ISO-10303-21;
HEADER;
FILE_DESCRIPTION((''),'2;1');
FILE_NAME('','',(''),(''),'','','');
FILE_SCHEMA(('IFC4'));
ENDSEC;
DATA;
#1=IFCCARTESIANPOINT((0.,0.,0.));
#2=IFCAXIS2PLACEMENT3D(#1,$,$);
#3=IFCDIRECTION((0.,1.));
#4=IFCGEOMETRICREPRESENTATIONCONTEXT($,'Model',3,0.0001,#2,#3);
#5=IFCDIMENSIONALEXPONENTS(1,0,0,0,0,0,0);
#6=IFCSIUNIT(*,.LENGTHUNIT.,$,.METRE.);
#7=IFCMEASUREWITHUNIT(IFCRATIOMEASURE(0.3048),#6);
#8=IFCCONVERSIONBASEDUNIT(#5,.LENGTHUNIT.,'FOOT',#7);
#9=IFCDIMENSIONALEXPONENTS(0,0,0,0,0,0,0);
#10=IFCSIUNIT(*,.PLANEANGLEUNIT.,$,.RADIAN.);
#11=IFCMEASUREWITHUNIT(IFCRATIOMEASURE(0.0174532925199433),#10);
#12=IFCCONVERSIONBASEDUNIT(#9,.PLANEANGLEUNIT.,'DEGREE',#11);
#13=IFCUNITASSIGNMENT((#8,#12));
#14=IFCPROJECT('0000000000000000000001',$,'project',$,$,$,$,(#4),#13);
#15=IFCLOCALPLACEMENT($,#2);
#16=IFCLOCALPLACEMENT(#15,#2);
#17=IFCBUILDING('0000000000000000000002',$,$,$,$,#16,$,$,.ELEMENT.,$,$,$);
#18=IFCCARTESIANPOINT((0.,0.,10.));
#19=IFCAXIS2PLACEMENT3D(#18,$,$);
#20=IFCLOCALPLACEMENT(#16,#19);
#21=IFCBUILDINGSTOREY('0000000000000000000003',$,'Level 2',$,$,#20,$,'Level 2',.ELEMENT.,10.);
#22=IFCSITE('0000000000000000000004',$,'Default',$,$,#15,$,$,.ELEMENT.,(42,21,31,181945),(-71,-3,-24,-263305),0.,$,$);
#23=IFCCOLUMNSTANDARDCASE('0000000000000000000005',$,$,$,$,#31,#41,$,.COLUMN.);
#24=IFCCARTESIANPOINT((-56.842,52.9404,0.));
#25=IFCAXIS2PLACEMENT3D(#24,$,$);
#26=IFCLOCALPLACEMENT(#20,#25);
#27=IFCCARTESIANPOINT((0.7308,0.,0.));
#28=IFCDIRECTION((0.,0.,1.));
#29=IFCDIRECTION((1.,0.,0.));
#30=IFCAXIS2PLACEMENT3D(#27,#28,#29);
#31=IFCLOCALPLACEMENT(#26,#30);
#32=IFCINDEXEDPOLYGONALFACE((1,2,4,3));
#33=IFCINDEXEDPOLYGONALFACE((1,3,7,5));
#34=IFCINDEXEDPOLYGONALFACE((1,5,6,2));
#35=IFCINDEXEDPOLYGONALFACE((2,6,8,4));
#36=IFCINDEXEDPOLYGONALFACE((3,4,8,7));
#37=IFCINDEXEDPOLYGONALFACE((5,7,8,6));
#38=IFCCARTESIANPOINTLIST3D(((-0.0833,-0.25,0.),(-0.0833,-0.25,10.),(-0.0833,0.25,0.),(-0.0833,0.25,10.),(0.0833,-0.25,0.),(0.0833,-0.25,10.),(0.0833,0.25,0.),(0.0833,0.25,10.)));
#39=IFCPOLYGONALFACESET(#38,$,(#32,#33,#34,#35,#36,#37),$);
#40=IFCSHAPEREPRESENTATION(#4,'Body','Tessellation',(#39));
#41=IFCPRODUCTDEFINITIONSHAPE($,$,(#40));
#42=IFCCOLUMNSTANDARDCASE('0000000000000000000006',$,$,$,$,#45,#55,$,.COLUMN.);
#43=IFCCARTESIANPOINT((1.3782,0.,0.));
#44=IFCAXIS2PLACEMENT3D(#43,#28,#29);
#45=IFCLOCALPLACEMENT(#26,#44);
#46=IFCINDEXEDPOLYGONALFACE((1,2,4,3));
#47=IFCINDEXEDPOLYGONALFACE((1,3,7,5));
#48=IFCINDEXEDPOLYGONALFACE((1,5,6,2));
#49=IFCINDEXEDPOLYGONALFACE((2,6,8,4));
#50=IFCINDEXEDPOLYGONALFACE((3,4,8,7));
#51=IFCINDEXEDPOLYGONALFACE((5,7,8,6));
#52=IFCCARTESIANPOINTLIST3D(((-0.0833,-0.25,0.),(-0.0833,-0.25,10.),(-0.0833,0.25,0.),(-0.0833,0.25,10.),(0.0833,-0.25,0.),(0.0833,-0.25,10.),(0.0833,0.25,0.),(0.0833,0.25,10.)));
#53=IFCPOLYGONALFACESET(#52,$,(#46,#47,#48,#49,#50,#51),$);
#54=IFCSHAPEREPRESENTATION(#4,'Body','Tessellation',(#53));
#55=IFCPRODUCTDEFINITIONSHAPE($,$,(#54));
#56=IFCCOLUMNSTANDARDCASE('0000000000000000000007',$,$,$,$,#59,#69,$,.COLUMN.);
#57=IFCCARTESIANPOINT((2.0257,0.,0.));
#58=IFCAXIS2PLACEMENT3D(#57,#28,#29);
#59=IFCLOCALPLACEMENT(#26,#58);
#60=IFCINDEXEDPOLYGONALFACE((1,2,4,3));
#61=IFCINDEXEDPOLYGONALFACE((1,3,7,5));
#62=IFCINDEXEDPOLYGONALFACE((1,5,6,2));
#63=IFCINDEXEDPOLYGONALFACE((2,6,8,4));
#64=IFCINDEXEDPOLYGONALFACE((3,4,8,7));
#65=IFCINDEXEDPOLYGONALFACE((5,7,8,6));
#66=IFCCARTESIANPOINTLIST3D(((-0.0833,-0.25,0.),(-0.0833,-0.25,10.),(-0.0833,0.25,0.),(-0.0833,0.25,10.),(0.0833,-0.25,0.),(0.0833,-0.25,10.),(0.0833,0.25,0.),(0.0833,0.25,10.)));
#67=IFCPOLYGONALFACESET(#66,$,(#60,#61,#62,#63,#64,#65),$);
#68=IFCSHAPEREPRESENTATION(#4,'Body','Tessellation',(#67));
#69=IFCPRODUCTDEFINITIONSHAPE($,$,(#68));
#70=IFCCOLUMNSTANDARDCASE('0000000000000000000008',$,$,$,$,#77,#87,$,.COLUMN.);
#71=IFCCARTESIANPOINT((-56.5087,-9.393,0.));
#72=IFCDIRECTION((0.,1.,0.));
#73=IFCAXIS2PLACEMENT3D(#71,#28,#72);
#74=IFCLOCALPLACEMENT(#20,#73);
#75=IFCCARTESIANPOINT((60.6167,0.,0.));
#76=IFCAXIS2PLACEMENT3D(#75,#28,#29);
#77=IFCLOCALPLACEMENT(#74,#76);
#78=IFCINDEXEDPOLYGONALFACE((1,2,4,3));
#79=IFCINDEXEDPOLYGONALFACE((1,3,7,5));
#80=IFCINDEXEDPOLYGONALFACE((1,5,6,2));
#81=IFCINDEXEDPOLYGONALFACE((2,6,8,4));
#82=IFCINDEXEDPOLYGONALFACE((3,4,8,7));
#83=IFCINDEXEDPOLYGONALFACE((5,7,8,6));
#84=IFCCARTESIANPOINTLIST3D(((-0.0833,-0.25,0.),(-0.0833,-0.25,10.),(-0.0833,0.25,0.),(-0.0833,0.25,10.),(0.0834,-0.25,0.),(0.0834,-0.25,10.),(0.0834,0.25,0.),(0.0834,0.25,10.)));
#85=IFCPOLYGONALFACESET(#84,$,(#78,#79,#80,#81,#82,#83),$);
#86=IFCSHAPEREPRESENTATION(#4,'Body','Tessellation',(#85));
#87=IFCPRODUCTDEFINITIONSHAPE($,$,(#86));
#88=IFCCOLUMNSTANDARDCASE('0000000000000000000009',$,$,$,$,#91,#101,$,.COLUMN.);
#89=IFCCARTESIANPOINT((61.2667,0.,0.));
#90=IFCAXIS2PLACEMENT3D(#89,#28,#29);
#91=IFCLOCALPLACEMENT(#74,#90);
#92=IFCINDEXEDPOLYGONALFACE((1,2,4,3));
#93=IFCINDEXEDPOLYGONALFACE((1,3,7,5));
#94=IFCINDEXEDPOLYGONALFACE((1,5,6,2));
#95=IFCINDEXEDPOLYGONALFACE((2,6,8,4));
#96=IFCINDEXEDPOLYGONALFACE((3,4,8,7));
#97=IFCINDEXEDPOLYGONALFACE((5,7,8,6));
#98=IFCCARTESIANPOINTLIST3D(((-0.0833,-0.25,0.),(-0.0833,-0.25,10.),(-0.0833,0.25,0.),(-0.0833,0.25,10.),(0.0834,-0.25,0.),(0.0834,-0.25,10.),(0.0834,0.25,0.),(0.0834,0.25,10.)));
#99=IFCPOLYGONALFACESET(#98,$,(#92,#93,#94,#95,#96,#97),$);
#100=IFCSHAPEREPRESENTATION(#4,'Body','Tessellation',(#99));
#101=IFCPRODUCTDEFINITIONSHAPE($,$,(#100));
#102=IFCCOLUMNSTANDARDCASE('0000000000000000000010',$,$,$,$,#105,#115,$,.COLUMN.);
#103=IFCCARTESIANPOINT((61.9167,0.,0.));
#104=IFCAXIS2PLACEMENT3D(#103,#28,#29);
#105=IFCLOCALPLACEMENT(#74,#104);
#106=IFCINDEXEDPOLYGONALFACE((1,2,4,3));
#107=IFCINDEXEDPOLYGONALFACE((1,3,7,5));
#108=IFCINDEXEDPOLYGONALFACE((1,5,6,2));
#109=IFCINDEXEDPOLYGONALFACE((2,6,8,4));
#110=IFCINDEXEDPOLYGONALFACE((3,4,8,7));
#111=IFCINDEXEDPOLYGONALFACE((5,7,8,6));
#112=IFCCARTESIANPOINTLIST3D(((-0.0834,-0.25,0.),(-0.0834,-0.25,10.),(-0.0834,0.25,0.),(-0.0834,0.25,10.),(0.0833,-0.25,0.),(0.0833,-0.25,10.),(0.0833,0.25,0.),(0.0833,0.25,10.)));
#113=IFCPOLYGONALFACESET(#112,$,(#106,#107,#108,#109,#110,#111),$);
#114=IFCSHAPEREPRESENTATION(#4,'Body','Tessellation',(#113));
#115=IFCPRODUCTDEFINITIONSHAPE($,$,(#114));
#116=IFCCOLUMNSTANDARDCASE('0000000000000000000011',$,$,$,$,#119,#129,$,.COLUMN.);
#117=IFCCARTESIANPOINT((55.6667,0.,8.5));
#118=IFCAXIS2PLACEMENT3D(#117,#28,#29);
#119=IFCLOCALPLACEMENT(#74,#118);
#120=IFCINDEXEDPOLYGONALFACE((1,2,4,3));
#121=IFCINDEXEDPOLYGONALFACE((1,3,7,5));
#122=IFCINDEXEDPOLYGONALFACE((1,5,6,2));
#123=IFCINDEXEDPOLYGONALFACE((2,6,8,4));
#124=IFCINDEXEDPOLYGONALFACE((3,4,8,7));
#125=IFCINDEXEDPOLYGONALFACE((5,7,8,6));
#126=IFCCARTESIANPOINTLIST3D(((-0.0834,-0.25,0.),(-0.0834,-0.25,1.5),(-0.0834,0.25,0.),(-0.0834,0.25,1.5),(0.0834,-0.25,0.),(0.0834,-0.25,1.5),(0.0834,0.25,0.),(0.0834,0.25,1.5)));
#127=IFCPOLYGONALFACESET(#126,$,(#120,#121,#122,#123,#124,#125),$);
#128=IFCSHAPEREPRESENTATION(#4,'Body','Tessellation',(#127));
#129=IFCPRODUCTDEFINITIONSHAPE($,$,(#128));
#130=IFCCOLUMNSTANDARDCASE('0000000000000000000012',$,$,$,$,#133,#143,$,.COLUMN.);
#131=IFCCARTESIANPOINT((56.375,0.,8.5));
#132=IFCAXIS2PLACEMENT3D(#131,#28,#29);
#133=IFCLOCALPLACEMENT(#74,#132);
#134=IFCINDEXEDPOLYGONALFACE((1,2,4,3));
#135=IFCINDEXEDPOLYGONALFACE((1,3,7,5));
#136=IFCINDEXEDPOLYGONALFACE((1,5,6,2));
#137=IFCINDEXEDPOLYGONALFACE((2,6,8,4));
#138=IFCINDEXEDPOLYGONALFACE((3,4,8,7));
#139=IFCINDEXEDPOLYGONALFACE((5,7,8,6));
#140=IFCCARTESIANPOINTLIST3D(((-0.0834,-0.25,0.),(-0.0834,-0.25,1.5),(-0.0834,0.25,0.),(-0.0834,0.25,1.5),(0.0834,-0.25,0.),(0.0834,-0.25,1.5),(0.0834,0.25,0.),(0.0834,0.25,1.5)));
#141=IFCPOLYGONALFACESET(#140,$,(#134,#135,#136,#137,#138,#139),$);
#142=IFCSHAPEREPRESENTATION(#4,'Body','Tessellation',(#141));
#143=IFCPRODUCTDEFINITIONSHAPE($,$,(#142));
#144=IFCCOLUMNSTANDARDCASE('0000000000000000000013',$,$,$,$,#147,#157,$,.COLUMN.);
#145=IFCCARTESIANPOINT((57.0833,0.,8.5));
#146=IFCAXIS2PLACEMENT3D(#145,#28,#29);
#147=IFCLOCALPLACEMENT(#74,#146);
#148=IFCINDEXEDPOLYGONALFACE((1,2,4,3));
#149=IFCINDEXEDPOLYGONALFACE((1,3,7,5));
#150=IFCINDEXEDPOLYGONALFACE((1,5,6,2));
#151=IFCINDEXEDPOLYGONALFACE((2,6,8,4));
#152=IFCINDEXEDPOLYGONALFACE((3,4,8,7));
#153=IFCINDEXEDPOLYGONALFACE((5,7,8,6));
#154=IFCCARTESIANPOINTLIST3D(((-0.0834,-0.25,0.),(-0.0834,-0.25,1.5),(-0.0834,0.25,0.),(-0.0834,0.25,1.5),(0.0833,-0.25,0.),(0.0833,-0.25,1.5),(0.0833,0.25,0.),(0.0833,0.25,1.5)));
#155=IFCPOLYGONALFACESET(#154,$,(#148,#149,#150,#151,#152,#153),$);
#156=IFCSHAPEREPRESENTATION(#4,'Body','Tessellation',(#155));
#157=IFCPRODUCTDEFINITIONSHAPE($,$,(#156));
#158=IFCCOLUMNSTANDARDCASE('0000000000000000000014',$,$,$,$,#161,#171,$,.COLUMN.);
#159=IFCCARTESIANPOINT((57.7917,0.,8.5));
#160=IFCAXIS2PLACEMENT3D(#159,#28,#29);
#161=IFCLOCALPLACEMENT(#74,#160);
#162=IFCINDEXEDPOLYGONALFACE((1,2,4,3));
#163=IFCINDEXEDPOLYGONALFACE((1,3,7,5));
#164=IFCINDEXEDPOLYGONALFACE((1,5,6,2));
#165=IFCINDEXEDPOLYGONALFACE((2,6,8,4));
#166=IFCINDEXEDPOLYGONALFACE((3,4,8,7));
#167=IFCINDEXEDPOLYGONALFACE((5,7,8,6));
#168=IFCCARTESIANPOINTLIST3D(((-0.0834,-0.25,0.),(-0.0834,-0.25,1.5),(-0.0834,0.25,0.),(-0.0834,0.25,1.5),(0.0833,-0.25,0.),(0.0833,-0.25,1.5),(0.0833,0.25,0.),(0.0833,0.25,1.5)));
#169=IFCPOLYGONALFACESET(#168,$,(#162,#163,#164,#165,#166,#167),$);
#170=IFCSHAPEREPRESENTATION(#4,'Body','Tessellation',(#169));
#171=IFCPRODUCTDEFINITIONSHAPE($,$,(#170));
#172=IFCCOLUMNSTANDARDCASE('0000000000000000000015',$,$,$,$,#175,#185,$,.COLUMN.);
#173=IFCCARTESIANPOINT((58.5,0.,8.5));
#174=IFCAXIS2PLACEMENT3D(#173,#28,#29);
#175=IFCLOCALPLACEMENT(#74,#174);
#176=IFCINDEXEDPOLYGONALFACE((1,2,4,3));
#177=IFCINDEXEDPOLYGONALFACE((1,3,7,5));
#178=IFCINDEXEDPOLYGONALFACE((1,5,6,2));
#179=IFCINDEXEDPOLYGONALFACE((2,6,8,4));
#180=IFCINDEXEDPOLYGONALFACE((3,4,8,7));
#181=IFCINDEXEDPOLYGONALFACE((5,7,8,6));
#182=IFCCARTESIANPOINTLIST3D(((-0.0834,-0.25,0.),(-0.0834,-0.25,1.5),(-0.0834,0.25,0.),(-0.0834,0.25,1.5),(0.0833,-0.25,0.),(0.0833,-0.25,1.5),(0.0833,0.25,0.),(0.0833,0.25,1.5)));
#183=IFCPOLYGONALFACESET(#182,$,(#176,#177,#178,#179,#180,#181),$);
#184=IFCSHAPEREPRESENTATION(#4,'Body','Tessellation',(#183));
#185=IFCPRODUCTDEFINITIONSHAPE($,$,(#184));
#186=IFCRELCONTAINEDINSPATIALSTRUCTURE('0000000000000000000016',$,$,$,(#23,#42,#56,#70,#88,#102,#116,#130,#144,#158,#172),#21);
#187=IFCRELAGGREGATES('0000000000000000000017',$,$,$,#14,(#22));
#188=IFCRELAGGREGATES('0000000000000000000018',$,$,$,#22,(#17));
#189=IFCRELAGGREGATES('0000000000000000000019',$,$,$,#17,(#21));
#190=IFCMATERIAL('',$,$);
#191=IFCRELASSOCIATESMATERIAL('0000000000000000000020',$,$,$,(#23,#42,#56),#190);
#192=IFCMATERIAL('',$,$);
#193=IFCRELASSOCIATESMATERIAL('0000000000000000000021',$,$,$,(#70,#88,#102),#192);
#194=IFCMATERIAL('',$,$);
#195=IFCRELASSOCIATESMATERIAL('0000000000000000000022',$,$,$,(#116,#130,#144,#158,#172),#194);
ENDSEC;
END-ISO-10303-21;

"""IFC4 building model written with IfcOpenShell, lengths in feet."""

from ifc_helpers import new_model, entity, si_unit, converted_unit, direction, frame, origin, place, context, project, spatial, rectangle, extrude, material, element, save


model = new_model("IFC4")

# Units and contexts
model_context = context("Model", 3, precision=0.0001, world=origin(), true_north=direction((0.0, 1.0)))
ifc_project = project(units=[converted_unit("LENGTHUNIT", "FOOT", entity("IfcRatioMeasure", 0.3048), si_unit("LENGTHUNIT", "METRE"), dimensions=[1, 0, 0, 0, 0, 0, 0]), converted_unit("PLANEANGLEUNIT", "DEGREE", entity("IfcRatioMeasure", 0.0174532925199433), si_unit("PLANEANGLEUNIT", "RADIAN"), dimensions=[0, 0, 0, 0, 0, 0, 0])], contexts=[model_context])

# Site, building, storey
site_placement = place(None, origin())
site = spatial("IfcSite", under=ifc_project, at=site_placement, Name="Default", CompositionType="ELEMENT", RefLatitude=(42, 21, 31, 181945), RefLongitude=(-71, -3, -24, -263305), RefElevation=0.0)
building_placement = place(site_placement, origin())
building = spatial("IfcBuilding", under=site, at=building_placement, CompositionType="ELEMENT")
storey_placement = place(building_placement, frame((0.0, 0.0, 10.0)))
storey = spatial("IfcBuildingStorey", under=building, at=storey_placement, Name="Level 2", LongName="Level 2", CompositionType="ELEMENT", Elevation=10.0)

# Columns
ifc_material_1 = material(Name="")
placement_1 = place(storey_placement, frame((-56.842, 52.9404, 0.0)))
for number, where, z_axis, x_axis in (
    (1, (0.7308, 0.0, 0.0), (0.0, 0.0, 1.0), (1.0, 0.0, 0.0)),
    (2, (1.3782, 0.0, 0.0), (0.0, 0.0, 1.0), (1.0, 0.0, 0.0)),
    (3, (2.0257, 0.0, 0.0), (0.0, 0.0, 1.0), (1.0, 0.0, 0.0)),
):
    element("IfcColumnStandardCase", number, at=place(placement_1, frame(where, z_axis=z_axis, x_axis=x_axis)), inside=storey, material=ifc_material_1, PredefinedType="COLUMN", context=model_context, shape_type="SweptSolid", body=[
        extrude(rectangle(XDim=0.1667, YDim=0.5), origin(), (0.0, 0.0, 1.0), 10.0),
    ])
ifc_material_2 = material(Name="")
placement_2 = place(storey_placement, frame((-56.5087, -9.393, 0.0), z_axis=(0.0, 0.0, 1.0), x_axis=(0.0, 1.0, 0.0)))
for number, where, z_axis, x_axis in (
    (4, (60.6167, 0.0, 0.0), (0.0, 0.0, 1.0), (1.0, 0.0, 0.0)),
    (5, (61.2667, 0.0, 0.0), (0.0, 0.0, 1.0), (1.0, 0.0, 0.0)),
    (6, (61.9167, 0.0, 0.0), (0.0, 0.0, 1.0), (1.0, 0.0, 0.0)),
):
    element("IfcColumnStandardCase", number, at=place(placement_2, frame(where, z_axis=z_axis, x_axis=x_axis)), inside=storey, material=ifc_material_2, PredefinedType="COLUMN", context=model_context, shape_type="SweptSolid", body=[
        extrude(rectangle(XDim=0.1667, YDim=0.5), origin(), (0.0, 0.0, 1.0), 10.0),
    ])
ifc_material_3 = material(Name="")
for number, where, z_axis, x_axis in (
    (7, (55.6667, 0.0, 8.5), (0.0, 0.0, 1.0), (1.0, 0.0, 0.0)),
    (8, (56.375, 0.0, 8.5), (0.0, 0.0, 1.0), (1.0, 0.0, 0.0)),
    (9, (57.0833, 0.0, 8.5), (0.0, 0.0, 1.0), (1.0, 0.0, 0.0)),
    (10, (57.7917, 0.0, 8.5), (0.0, 0.0, 1.0), (1.0, 0.0, 0.0)),
    (11, (58.5, 0.0, 8.5), (0.0, 0.0, 1.0), (1.0, 0.0, 0.0)),
):
    element("IfcColumnStandardCase", number, at=place(placement_2, frame(where, z_axis=z_axis, x_axis=x_axis)), inside=storey, material=ifc_material_3, PredefinedType="COLUMN", context=model_context, shape_type="SweptSolid", body=[
        extrude(rectangle(XDim=0.1667, YDim=0.5), origin(), (0.0, 0.0, 1.0), 1.5),
    ])

save(model, "model.ifc")
